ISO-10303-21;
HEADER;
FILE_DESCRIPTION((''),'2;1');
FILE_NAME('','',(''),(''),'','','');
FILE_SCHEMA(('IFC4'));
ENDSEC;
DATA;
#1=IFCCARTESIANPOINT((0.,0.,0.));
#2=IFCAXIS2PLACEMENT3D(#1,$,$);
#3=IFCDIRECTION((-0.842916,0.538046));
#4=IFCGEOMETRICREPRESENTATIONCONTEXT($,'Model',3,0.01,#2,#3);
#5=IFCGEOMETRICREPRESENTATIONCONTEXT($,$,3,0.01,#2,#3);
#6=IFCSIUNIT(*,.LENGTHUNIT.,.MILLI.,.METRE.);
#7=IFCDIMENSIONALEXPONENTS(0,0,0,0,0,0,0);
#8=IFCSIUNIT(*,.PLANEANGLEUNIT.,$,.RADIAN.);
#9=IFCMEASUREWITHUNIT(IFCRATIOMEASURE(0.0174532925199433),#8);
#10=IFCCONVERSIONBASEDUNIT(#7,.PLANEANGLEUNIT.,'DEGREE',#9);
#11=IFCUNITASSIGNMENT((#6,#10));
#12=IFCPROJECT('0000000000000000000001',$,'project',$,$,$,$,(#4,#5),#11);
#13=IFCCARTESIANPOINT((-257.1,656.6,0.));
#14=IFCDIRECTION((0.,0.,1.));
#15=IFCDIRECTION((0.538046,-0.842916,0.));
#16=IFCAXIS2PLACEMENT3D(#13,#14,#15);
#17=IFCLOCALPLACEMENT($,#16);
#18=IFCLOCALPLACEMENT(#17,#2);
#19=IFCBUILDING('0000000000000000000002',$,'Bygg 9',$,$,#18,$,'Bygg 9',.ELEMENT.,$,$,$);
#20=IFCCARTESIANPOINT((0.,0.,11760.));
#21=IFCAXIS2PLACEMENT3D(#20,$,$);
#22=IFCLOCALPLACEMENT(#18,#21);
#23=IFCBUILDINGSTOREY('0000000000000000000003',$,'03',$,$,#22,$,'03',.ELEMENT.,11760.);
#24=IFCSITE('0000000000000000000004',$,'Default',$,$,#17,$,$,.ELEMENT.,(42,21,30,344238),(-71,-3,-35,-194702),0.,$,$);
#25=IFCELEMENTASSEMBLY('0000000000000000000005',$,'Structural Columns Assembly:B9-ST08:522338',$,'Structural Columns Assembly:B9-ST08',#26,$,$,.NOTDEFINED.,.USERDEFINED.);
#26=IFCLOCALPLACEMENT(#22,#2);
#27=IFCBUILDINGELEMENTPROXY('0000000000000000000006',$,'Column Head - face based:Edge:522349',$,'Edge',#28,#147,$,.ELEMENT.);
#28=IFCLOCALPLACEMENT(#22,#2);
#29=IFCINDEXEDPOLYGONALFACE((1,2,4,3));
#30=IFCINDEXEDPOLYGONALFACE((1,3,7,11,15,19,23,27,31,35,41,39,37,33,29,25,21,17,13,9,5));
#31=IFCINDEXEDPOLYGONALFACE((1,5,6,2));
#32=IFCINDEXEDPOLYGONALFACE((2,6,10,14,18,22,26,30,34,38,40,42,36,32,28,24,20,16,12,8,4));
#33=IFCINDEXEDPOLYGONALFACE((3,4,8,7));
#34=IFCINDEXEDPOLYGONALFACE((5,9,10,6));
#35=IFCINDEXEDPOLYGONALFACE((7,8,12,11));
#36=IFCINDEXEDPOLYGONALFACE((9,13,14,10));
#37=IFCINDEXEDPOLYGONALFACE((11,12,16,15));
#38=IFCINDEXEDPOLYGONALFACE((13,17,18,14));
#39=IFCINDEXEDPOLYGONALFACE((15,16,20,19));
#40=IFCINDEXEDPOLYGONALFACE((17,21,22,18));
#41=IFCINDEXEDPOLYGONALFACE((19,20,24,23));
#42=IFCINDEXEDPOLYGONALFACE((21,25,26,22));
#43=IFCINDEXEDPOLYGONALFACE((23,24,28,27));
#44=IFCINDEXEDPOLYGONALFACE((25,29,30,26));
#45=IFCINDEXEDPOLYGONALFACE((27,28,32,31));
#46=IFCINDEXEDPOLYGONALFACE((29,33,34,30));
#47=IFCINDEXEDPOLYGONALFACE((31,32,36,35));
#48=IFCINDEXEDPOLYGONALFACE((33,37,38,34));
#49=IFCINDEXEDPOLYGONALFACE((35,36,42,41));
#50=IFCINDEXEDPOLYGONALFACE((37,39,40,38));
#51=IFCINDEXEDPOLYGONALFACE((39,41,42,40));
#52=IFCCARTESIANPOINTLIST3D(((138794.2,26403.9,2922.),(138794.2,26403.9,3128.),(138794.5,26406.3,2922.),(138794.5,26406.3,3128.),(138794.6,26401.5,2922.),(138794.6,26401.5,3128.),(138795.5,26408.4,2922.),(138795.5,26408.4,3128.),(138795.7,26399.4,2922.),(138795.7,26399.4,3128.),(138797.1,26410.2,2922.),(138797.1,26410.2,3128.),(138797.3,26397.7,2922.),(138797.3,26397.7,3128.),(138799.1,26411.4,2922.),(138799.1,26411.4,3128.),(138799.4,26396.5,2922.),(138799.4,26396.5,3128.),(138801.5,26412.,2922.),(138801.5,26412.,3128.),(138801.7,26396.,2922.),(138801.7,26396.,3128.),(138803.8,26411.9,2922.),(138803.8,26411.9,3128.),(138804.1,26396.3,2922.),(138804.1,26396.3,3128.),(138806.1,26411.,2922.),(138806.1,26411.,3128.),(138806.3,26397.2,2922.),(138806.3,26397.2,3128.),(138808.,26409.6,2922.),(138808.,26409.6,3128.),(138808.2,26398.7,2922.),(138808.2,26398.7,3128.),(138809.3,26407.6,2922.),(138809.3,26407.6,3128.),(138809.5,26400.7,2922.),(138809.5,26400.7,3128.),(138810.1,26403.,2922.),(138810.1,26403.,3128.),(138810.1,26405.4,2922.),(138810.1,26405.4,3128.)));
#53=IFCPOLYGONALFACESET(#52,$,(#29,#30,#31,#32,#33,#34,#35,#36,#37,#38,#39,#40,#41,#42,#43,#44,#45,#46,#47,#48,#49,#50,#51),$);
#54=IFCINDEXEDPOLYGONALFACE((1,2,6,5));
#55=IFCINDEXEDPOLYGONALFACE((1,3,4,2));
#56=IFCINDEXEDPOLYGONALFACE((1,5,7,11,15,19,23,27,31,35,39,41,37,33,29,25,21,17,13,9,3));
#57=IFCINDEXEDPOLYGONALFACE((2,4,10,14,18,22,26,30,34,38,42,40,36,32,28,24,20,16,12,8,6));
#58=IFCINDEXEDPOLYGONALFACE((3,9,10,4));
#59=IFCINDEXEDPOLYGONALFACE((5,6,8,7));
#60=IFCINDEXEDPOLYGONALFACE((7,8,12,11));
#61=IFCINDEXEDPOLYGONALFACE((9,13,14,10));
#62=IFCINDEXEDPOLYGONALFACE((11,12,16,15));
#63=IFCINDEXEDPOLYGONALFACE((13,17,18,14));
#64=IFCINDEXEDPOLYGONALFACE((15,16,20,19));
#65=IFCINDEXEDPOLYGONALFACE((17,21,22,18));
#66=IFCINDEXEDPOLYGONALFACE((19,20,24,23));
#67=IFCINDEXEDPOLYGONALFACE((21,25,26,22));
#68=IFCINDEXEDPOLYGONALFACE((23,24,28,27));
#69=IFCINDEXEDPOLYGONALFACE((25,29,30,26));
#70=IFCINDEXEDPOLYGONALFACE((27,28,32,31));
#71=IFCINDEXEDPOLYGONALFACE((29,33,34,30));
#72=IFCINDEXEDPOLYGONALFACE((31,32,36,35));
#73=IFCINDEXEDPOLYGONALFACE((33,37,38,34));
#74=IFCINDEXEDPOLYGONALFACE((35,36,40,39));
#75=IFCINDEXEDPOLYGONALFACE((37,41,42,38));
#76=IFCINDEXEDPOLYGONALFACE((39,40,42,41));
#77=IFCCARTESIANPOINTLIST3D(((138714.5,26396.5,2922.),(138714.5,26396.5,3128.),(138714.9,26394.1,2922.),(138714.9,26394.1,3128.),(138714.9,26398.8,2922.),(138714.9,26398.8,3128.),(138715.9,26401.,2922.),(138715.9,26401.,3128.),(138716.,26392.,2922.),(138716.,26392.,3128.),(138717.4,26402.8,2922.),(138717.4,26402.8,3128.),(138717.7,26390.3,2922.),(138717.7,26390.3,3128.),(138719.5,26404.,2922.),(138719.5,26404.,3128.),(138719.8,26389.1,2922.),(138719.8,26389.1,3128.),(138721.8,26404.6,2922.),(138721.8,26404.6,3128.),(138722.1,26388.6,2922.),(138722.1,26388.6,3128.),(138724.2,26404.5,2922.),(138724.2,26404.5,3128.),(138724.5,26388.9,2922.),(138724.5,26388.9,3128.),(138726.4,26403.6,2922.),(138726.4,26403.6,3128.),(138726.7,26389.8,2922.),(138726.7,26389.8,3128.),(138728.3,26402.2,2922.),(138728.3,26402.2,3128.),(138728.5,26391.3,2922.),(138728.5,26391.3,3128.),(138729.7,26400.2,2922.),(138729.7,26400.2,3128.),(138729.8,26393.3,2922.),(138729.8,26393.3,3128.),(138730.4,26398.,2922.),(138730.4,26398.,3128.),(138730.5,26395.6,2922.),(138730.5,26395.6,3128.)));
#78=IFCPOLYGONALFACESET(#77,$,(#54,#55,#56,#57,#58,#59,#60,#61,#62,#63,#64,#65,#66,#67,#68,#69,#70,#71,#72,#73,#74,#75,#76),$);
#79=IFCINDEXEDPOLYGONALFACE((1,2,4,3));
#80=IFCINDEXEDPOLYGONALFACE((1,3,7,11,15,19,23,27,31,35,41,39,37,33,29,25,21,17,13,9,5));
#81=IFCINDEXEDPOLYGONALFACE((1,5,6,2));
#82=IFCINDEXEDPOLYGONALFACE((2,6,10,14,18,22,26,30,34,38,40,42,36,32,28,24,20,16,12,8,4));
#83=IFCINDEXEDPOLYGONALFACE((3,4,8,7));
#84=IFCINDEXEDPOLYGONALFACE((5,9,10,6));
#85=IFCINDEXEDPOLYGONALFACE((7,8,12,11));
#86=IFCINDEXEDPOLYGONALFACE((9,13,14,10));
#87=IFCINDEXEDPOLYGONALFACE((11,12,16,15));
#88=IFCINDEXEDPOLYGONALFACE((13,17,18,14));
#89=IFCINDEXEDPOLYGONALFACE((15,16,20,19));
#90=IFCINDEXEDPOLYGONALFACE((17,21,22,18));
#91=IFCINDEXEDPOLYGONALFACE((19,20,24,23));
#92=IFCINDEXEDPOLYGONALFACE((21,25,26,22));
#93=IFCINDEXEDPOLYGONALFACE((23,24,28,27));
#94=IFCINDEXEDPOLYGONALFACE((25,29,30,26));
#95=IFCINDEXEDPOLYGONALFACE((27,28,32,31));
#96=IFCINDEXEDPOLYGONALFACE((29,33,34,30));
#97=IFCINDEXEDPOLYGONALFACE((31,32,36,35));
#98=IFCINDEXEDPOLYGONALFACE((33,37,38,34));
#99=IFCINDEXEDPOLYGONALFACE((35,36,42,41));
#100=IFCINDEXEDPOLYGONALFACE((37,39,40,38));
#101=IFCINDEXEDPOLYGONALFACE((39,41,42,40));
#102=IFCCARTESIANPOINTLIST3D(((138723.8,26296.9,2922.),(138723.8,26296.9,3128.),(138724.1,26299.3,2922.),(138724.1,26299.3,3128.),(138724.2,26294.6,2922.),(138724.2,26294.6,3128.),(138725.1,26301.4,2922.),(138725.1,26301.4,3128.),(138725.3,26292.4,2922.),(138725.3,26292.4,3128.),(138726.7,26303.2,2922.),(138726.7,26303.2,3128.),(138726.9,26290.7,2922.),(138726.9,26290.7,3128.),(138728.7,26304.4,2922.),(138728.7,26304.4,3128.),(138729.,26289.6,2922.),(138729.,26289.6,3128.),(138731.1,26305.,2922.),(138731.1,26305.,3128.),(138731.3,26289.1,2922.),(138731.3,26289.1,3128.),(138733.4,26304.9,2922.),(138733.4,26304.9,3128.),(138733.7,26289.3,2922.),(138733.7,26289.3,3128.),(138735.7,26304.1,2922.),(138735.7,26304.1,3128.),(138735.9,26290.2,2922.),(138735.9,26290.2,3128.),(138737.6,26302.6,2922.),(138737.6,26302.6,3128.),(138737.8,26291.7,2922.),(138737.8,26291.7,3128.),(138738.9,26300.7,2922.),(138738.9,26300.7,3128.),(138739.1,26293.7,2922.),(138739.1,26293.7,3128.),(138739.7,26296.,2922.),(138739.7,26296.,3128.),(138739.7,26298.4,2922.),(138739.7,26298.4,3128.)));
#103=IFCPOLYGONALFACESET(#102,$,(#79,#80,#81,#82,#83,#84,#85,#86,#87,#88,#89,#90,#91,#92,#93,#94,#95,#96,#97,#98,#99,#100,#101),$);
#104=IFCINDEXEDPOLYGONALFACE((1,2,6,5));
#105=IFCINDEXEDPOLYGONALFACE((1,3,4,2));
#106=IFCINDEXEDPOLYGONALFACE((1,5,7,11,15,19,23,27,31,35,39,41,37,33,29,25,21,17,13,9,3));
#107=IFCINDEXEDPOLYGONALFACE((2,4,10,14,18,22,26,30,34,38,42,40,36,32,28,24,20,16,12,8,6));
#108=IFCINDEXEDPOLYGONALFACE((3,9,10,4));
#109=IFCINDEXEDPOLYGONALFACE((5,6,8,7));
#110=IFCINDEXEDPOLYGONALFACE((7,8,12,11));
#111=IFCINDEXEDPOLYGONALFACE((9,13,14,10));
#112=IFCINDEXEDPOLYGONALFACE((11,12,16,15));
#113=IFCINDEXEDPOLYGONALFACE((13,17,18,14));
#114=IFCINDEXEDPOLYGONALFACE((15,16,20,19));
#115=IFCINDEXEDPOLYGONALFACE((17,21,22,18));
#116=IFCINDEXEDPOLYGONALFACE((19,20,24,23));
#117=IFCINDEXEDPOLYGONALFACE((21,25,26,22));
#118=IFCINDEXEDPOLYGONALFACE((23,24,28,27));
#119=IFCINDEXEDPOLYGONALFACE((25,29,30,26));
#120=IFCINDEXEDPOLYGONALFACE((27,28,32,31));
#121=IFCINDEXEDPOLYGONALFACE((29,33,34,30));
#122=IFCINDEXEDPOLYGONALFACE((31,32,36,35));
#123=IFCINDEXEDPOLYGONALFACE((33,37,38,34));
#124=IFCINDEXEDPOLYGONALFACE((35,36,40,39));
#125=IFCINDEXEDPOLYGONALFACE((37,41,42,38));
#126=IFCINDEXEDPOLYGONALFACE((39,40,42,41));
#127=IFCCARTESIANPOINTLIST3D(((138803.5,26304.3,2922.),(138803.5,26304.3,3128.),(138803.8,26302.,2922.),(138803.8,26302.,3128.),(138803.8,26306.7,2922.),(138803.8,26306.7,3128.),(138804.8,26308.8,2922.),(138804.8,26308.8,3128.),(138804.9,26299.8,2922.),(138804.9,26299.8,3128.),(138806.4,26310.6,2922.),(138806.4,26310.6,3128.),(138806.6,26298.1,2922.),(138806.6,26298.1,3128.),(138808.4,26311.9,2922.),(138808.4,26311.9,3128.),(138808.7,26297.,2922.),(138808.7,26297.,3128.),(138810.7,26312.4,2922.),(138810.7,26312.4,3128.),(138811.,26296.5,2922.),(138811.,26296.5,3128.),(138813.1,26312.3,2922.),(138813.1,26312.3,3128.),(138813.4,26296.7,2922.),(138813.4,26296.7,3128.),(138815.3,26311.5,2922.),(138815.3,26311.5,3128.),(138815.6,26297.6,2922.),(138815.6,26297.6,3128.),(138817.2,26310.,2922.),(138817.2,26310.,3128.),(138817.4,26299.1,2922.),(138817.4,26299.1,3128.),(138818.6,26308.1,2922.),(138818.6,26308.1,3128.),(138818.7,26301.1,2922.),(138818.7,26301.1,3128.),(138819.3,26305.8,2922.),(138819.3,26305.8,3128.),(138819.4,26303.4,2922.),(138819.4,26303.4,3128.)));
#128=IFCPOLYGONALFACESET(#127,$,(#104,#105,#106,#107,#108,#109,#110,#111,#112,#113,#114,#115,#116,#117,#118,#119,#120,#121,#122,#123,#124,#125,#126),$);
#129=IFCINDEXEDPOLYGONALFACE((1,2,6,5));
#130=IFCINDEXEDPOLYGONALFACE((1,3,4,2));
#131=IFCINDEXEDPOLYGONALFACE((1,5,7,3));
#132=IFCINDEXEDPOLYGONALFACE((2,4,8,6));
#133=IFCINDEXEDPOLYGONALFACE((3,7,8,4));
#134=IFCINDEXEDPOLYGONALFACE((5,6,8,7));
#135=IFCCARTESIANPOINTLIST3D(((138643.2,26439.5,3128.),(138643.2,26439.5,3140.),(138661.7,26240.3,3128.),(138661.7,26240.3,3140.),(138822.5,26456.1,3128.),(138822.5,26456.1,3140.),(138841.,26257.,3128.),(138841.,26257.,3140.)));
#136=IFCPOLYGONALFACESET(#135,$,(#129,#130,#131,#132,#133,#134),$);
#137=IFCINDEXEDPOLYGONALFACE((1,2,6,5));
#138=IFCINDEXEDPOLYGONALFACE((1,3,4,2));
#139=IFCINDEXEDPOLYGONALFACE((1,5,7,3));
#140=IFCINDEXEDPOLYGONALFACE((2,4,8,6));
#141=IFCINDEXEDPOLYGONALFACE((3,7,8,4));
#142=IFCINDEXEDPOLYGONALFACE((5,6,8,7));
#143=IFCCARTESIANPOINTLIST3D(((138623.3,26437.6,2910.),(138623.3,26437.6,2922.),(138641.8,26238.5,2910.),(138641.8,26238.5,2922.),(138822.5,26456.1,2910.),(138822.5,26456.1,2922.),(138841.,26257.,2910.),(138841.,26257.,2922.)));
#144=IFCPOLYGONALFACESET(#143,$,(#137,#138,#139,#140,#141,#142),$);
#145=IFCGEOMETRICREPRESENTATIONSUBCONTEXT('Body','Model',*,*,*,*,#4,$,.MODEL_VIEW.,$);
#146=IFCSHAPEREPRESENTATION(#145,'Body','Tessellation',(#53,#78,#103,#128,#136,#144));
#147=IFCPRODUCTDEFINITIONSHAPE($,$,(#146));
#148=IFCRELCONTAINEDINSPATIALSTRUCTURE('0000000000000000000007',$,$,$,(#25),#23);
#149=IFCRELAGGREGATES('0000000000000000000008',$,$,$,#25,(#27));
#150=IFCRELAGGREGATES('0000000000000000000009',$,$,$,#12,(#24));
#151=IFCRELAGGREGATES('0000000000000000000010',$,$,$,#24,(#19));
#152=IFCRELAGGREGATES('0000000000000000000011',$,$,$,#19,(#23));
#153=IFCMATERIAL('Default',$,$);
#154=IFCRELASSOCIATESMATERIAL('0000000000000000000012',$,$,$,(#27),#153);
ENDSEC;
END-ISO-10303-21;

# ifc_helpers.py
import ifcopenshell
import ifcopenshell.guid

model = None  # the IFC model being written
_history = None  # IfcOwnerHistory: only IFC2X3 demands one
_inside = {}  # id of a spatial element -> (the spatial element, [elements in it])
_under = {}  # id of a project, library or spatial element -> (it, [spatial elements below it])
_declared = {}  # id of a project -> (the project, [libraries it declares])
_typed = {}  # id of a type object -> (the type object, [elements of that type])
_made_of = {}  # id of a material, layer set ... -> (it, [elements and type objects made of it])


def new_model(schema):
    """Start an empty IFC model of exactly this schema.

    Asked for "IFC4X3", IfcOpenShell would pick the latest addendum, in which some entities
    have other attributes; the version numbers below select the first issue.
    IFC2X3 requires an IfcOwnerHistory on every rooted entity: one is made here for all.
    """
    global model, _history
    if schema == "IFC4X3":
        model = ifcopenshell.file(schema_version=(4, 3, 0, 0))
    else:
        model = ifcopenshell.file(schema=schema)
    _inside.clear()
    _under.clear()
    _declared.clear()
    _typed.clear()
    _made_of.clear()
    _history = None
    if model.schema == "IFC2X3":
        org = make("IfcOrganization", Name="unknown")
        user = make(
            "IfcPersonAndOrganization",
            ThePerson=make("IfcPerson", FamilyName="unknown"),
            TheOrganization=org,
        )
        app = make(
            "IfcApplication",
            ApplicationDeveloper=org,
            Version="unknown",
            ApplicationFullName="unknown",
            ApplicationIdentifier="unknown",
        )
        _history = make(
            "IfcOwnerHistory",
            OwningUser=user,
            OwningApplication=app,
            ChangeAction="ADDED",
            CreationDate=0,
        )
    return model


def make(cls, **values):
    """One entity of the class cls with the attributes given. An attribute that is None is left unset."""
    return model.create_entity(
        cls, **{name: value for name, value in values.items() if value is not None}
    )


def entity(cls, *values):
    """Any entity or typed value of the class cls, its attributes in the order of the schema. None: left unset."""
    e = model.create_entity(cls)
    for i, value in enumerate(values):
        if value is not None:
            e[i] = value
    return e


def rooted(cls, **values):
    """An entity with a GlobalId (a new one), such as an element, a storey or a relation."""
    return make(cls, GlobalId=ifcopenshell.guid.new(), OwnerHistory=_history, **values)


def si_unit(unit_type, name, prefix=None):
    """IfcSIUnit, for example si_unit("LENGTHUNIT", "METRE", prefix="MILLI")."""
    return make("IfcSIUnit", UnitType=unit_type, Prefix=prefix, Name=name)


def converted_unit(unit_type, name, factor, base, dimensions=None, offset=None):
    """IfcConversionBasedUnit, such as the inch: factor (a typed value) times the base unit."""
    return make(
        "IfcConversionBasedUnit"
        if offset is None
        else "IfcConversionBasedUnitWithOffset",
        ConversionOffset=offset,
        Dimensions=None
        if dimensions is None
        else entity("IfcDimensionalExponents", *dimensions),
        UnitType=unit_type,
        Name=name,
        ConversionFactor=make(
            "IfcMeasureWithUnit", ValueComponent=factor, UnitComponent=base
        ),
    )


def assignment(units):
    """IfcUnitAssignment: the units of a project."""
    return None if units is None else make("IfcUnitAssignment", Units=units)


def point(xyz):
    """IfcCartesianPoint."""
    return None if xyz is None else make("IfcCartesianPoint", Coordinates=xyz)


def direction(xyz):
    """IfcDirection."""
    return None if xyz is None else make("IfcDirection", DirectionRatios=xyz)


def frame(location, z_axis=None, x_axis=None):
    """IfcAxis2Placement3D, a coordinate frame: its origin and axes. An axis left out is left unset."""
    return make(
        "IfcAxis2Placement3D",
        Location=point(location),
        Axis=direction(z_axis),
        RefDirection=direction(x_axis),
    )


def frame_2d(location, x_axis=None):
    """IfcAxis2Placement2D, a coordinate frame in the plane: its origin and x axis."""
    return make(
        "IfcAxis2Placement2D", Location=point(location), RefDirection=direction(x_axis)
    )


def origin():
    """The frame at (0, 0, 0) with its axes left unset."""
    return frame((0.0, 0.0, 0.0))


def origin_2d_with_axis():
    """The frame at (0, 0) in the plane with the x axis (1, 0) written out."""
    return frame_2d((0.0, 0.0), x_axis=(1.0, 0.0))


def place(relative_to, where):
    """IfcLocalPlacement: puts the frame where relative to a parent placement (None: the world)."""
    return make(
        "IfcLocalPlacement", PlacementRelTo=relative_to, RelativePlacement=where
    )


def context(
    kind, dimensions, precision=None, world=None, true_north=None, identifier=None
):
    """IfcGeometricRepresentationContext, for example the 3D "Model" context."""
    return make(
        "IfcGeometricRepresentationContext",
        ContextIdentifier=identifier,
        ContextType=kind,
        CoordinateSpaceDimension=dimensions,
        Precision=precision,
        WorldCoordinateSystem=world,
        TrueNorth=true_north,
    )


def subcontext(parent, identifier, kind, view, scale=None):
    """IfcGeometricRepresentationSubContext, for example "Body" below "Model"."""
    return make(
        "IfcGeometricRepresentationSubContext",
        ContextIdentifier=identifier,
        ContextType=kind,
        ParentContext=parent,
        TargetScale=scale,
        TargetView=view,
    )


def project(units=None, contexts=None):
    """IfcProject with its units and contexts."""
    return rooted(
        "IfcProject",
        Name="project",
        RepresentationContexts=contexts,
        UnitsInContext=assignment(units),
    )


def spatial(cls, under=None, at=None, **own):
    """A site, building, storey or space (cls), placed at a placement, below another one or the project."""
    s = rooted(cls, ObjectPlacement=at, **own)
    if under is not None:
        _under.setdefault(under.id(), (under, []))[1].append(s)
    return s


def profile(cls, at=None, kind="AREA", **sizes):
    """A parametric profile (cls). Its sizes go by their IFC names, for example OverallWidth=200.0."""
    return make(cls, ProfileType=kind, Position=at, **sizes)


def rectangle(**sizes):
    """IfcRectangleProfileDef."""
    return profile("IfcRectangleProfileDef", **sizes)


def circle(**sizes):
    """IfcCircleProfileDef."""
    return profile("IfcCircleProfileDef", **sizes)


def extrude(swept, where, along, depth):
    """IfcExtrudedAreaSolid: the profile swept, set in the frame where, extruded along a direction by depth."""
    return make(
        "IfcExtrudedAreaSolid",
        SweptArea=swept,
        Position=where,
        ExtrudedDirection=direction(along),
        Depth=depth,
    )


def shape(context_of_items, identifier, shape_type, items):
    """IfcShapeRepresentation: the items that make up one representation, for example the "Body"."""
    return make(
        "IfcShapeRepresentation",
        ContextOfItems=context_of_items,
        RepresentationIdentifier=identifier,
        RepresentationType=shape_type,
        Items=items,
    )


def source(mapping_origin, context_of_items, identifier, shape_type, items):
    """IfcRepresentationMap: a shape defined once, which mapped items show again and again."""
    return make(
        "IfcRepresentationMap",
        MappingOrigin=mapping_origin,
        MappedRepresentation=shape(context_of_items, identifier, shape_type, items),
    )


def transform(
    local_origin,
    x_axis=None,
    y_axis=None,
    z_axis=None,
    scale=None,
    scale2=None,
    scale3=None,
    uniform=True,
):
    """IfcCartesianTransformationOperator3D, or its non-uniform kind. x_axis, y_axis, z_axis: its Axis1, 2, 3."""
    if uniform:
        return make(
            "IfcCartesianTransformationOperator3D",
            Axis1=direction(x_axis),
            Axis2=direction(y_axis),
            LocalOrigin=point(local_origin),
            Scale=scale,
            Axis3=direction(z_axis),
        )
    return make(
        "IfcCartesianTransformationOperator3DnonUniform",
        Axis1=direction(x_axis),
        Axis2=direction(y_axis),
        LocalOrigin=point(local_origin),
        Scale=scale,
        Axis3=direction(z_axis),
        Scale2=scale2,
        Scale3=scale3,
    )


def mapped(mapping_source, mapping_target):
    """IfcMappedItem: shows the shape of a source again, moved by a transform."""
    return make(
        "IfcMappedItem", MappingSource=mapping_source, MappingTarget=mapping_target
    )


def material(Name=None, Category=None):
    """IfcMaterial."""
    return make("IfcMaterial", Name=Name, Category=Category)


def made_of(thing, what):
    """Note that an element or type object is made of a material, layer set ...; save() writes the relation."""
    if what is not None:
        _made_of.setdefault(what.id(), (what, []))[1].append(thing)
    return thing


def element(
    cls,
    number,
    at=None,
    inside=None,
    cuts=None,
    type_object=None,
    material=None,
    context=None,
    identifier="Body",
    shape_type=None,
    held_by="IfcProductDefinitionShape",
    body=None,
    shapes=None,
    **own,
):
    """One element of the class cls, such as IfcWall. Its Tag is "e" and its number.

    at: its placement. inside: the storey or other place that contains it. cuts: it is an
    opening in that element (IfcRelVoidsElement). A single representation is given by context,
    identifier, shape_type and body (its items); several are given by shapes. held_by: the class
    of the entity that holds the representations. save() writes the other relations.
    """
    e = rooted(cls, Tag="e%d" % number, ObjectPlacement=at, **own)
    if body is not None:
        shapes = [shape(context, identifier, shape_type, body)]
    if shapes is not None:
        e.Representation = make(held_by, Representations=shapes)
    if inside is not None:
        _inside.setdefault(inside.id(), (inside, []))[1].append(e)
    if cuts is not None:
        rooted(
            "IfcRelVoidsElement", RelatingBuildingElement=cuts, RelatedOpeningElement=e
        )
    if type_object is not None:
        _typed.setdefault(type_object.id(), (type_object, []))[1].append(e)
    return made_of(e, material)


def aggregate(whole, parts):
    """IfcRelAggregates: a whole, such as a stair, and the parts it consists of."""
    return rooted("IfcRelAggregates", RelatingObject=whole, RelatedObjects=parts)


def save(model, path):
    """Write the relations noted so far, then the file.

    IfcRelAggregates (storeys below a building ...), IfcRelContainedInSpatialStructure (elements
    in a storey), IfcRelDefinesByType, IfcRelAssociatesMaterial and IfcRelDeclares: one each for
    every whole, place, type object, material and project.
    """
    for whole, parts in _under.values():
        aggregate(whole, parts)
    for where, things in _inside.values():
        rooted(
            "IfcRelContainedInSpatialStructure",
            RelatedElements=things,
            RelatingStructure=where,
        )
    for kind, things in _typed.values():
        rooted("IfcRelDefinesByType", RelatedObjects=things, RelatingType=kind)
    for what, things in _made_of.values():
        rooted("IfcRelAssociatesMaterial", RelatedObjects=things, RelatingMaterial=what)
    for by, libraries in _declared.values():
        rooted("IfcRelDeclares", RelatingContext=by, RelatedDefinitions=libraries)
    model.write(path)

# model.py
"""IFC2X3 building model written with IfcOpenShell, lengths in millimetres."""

from ifc_helpers import new_model, entity, si_unit, converted_unit, direction, frame, frame_2d, origin, origin_2d_with_axis, place, context, subcontext, project, spatial, rectangle, circle, extrude, source, transform, mapped, material, element, aggregate, save


model = new_model("IFC2X3")

# Units and contexts
model_context = context("Model", 3, precision=0.01, world=origin(), true_north=direction((-0.842916, 0.538046)))
context_of_model = context(None, 3, precision=0.01, world=origin(), true_north=direction((-0.842916, 0.538046)))
body_context = subcontext(model_context, "Body", "Model", "MODEL_VIEW")
ifc_project = project(units=[si_unit("LENGTHUNIT", "METRE", prefix="MILLI"), converted_unit("PLANEANGLEUNIT", "DEGREE", entity("IfcRatioMeasure", 0.0174532925199433), si_unit("PLANEANGLEUNIT", "RADIAN"), dimensions=[0, 0, 0, 0, 0, 0, 0])], contexts=[model_context, context_of_model])

# Site, building, storey
site_placement = place(None, frame((-257.1, 656.6, 0.0), z_axis=(0.0, 0.0, 1.0), x_axis=(0.538046, -0.842916, 0.0)))
site = spatial("IfcSite", under=ifc_project, at=site_placement, Name="Default", CompositionType="ELEMENT", RefLatitude=(42, 21, 30, 344238), RefLongitude=(-71, -3, -35, -194702), RefElevation=0.0)
building_placement = place(site_placement, origin())
building = spatial("IfcBuilding", under=site, at=building_placement, Name="Bygg 9", LongName="Bygg 9", CompositionType="ELEMENT")
storey_placement = place(building_placement, frame((0.0, 0.0, 11760.0)))
storey = spatial("IfcBuildingStorey", under=building, at=storey_placement, Name="03", LongName="03", CompositionType="ELEMENT", Elevation=11760.0)

# Shared definitions
ifc_material_1 = material(Name="Default")

# Element assembly, building element proxy
shared_shape_1 = source(origin(), body_context, "Body", "SweptSolid", [
    extrude(circle(Radius=8.0, at=frame_2d((0.0, 0.0), x_axis=(1.0, 0.0))), frame((50.0, -135.0, 12.0)), (0.0, 0.0, 1.0), 206.0),
    extrude(circle(Radius=8.0, at=frame_2d((0.0, 0.0), x_axis=(1.0, 0.0))), frame((50.0, -55.0, 12.0)), (0.0, 0.0, 1.0), 206.0),
    extrude(circle(Radius=8.0, at=frame_2d((0.0, 0.0), x_axis=(1.0, 0.0))), frame((-50.0, -55.0, 12.0)), (0.0, 0.0, 1.0), 206.0),
    extrude(circle(Radius=8.0, at=frame_2d((0.0, 0.0), x_axis=(1.0, 0.0))), frame((-50.0, -135.0, 12.0)), (0.0, 0.0, 1.0), 206.0),
    extrude(rectangle(XDim=200.0, YDim=180.0, at=origin_2d_with_axis()), frame((0.0, -70.0, 218.0), z_axis=(0.0, 0.0, 1.0), x_axis=(-1.0, 0.0, 0.0)), (0.0, 0.0, 1.0), 12.0),
    extrude(rectangle(XDim=200.0, YDim=200.0, at=origin_2d_with_axis()), frame((0.0, -60.0, 0.0), z_axis=(0.0, 0.0, 1.0), x_axis=(0.0, 1.0, 0.0)), (0.0, 0.0, 1.0), 12.0),
])
assembly_1_placement = place(storey_placement, origin())
assembly_1 = element("IfcElementAssembly", 1, at=assembly_1_placement, inside=storey, Name="Structural Columns Assembly:B9-ST08:522338", ObjectType="Structural Columns Assembly:B9-ST08", AssemblyPlace="NOTDEFINED", PredefinedType="USERDEFINED")
proxy_1_placement = place(assembly_1_placement, frame((138672.4, 26341.8, 2910.0), z_axis=(0.0, 0.0, 1.0), x_axis=(-0.092535, 0.995709, 0.0)))
proxy_1 = element("IfcBuildingElementProxy", 2, at=proxy_1_placement, material=ifc_material_1, Name="Column Head - face based:Edge:522349", ObjectType="Edge", CompositionType="ELEMENT", context=body_context, shape_type="MappedRepresentation", body=[
    mapped(shared_shape_1, transform((0.0, 0.0, 0.0), scale=1.0)),
])
aggregate(assembly_1, [proxy_1])

save(model, "model.ifc")
